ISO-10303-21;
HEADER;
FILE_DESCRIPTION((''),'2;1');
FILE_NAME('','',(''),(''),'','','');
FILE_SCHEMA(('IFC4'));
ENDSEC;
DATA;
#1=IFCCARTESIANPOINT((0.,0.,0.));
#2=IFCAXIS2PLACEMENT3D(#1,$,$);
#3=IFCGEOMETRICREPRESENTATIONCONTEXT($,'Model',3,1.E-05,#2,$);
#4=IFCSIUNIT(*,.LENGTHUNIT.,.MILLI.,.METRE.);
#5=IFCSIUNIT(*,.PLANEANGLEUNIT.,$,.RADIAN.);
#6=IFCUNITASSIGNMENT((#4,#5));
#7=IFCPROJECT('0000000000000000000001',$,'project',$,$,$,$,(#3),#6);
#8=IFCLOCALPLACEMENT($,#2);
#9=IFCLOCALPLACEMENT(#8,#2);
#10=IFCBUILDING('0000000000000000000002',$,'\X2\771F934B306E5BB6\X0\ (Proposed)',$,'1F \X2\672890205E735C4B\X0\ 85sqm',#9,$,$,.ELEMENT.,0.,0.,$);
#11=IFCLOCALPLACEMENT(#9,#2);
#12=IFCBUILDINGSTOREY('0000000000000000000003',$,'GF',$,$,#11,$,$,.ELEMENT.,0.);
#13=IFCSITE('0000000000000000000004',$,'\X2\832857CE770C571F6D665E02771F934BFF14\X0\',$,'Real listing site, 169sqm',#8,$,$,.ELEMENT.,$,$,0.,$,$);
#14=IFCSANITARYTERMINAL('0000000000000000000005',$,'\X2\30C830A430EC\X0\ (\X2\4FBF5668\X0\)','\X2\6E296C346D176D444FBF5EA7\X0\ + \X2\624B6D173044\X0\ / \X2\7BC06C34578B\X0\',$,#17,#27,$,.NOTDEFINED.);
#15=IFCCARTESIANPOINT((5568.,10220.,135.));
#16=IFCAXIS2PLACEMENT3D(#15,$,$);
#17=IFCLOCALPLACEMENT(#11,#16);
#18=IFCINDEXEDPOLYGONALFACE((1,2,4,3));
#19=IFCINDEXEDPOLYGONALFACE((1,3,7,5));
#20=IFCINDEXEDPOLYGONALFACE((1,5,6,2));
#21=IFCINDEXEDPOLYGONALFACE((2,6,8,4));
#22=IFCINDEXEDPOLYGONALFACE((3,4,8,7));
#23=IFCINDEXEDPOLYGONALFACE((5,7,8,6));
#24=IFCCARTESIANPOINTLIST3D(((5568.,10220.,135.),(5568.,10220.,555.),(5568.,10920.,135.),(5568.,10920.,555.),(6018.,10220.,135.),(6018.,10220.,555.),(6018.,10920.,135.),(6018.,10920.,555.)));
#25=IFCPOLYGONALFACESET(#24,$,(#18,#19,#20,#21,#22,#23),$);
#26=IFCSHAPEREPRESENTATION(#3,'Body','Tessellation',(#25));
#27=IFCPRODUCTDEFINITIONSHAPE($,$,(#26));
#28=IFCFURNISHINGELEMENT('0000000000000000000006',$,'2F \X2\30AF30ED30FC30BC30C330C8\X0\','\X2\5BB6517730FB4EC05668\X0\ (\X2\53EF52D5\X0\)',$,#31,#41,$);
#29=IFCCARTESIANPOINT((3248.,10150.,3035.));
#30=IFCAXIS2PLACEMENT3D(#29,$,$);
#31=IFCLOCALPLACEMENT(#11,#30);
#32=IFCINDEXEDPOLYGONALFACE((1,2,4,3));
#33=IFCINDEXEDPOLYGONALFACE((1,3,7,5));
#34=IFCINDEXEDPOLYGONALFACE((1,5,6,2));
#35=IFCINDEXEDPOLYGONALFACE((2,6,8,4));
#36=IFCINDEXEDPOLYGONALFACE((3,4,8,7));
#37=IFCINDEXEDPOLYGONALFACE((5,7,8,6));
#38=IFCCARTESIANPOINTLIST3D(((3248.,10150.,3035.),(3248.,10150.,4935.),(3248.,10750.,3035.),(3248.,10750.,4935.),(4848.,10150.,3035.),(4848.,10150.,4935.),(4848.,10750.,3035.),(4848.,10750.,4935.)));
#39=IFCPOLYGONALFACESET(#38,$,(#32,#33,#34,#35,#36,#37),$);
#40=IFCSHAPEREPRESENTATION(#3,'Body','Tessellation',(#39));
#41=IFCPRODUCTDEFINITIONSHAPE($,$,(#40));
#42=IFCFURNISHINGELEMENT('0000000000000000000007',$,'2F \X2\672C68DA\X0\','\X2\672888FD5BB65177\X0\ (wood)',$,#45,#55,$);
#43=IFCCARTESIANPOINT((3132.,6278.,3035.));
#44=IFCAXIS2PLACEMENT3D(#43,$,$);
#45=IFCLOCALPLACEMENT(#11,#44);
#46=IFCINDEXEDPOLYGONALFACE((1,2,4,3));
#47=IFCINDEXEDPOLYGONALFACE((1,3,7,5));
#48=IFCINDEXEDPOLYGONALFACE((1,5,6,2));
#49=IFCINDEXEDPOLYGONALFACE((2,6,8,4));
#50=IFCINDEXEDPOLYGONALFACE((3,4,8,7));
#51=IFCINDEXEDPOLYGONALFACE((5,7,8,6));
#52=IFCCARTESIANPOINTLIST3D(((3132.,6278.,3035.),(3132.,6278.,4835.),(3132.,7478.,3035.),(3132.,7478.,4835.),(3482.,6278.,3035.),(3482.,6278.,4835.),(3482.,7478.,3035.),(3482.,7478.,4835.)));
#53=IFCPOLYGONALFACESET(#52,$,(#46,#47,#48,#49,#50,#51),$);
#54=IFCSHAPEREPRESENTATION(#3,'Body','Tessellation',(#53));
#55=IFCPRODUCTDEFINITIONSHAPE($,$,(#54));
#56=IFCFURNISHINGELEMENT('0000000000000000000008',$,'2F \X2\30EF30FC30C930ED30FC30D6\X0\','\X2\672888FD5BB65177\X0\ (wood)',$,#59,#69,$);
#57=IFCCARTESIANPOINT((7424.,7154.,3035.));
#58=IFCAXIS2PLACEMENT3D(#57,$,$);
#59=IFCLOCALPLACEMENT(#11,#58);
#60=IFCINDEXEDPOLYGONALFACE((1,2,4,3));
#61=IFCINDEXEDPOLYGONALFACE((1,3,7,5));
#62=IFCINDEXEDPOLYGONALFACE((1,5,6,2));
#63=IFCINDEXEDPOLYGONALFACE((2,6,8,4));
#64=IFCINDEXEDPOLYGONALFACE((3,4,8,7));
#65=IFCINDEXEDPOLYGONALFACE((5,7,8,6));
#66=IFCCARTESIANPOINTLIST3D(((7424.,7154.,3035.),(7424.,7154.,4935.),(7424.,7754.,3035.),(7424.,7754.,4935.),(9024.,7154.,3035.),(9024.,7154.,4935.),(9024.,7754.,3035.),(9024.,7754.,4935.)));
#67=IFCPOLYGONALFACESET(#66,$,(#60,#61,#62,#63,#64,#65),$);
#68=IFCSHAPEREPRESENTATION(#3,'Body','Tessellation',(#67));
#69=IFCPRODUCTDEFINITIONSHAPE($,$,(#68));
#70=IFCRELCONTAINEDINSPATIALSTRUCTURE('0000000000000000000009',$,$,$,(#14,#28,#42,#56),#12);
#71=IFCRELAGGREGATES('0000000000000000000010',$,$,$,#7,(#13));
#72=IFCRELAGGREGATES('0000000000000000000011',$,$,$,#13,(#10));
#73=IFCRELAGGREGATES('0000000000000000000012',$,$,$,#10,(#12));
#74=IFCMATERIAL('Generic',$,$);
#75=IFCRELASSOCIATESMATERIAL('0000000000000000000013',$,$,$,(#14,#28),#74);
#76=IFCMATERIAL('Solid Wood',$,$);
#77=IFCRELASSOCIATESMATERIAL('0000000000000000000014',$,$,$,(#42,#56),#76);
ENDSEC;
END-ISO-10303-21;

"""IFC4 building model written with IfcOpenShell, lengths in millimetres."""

from ifc_helpers import new_model, si_unit, frame, frame_2d, origin, place, context, project, spatial, rectangle, extrude, material, element, save


model = new_model("IFC4")

# Units and contexts
model_context = context("Model", 3, precision=1e-05, world=origin())
ifc_project = project(units=[si_unit("LENGTHUNIT", "METRE", prefix="MILLI"), si_unit("PLANEANGLEUNIT", "RADIAN")], contexts=[model_context])

# Site, building, storey
site_placement = place(None, origin())
site = spatial("IfcSite", under=ifc_project, at=site_placement, Name="茨城県土浦市真鍋４", ObjectType="Real listing site, 169sqm", CompositionType="ELEMENT", RefElevation=0.0)
building_placement = place(site_placement, origin())
building = spatial("IfcBuilding", under=site, at=building_placement, Name="真鍋の家 (Proposed)", ObjectType="1F 木造平屋 85sqm", CompositionType="ELEMENT", ElevationOfRefHeight=0.0, ElevationOfTerrain=0.0)
storey_placement = place(building_placement, origin())
storey = spatial("IfcBuildingStorey", under=building, at=storey_placement, Name="GF", CompositionType="ELEMENT", Elevation=0.0)

# Shared definitions
ifc_material_1 = material(Name="Solid Wood")

# Shared definitions
ifc_material_2 = material(Name="Generic")

# Sanitary terminal
sanitary_terminal_placement = place(storey_placement, frame((5568.0, 10220.0, 135.0)))
element("IfcSanitaryTerminal", 1, at=sanitary_terminal_placement, inside=storey, material=ifc_material_2, Name="トイレ (便器)", Description="温水洗浄便座 + 手洗い / 節水型", PredefinedType="NOTDEFINED", context=model_context, shape_type="SweptSolid", body=[
    extrude(rectangle(XDim=450.0, YDim=700.0, at=frame_2d((225.0, 350.0))), frame((5568.0, 10220.0, 135.0)), (0.0, 0.0, 1.0), 420.0),
])

# Furnishing elements
furnishing_1_placement = place(storey_placement, frame((3248.0, 10150.0, 3035.0)))
element("IfcFurnishingElement", 2, at=furnishing_1_placement, inside=storey, material=ifc_material_2, Name="2F クローゼット", Description="家具・什器 (可動)", context=model_context, shape_type="SweptSolid", body=[
    extrude(rectangle(XDim=1600.0, YDim=600.0, at=frame_2d((800.0, 300.0))), frame((3248.0, 10150.0, 3035.0)), (0.0, 0.0, 1.0), 1900.0),
])
furnishing_2_placement = place(storey_placement, frame((3132.0, 6278.0, 3035.0)))
element("IfcFurnishingElement", 3, at=furnishing_2_placement, inside=storey, material=ifc_material_1, Name="2F 本棚", Description="木製家具 (wood)", context=model_context, shape_type="SweptSolid", body=[
    extrude(rectangle(XDim=350.0, YDim=1200.0, at=frame_2d((175.0, 600.0))), frame((3132.0, 6278.0, 3035.0)), (0.0, 0.0, 1.0), 1800.0),
])
furnishing_3_placement = place(storey_placement, frame((7424.0, 7154.0, 3035.0)))
element("IfcFurnishingElement", 4, at=furnishing_3_placement, inside=storey, material=ifc_material_1, Name="2F ワードローブ", Description="木製家具 (wood)", context=model_context, shape_type="SweptSolid", body=[
    extrude(rectangle(XDim=1600.0, YDim=600.0, at=frame_2d((800.0, 300.0))), frame((7424.0, 7154.0, 3035.0)), (0.0, 0.0, 1.0), 1900.0),
])

save(model, "model.ifc")
